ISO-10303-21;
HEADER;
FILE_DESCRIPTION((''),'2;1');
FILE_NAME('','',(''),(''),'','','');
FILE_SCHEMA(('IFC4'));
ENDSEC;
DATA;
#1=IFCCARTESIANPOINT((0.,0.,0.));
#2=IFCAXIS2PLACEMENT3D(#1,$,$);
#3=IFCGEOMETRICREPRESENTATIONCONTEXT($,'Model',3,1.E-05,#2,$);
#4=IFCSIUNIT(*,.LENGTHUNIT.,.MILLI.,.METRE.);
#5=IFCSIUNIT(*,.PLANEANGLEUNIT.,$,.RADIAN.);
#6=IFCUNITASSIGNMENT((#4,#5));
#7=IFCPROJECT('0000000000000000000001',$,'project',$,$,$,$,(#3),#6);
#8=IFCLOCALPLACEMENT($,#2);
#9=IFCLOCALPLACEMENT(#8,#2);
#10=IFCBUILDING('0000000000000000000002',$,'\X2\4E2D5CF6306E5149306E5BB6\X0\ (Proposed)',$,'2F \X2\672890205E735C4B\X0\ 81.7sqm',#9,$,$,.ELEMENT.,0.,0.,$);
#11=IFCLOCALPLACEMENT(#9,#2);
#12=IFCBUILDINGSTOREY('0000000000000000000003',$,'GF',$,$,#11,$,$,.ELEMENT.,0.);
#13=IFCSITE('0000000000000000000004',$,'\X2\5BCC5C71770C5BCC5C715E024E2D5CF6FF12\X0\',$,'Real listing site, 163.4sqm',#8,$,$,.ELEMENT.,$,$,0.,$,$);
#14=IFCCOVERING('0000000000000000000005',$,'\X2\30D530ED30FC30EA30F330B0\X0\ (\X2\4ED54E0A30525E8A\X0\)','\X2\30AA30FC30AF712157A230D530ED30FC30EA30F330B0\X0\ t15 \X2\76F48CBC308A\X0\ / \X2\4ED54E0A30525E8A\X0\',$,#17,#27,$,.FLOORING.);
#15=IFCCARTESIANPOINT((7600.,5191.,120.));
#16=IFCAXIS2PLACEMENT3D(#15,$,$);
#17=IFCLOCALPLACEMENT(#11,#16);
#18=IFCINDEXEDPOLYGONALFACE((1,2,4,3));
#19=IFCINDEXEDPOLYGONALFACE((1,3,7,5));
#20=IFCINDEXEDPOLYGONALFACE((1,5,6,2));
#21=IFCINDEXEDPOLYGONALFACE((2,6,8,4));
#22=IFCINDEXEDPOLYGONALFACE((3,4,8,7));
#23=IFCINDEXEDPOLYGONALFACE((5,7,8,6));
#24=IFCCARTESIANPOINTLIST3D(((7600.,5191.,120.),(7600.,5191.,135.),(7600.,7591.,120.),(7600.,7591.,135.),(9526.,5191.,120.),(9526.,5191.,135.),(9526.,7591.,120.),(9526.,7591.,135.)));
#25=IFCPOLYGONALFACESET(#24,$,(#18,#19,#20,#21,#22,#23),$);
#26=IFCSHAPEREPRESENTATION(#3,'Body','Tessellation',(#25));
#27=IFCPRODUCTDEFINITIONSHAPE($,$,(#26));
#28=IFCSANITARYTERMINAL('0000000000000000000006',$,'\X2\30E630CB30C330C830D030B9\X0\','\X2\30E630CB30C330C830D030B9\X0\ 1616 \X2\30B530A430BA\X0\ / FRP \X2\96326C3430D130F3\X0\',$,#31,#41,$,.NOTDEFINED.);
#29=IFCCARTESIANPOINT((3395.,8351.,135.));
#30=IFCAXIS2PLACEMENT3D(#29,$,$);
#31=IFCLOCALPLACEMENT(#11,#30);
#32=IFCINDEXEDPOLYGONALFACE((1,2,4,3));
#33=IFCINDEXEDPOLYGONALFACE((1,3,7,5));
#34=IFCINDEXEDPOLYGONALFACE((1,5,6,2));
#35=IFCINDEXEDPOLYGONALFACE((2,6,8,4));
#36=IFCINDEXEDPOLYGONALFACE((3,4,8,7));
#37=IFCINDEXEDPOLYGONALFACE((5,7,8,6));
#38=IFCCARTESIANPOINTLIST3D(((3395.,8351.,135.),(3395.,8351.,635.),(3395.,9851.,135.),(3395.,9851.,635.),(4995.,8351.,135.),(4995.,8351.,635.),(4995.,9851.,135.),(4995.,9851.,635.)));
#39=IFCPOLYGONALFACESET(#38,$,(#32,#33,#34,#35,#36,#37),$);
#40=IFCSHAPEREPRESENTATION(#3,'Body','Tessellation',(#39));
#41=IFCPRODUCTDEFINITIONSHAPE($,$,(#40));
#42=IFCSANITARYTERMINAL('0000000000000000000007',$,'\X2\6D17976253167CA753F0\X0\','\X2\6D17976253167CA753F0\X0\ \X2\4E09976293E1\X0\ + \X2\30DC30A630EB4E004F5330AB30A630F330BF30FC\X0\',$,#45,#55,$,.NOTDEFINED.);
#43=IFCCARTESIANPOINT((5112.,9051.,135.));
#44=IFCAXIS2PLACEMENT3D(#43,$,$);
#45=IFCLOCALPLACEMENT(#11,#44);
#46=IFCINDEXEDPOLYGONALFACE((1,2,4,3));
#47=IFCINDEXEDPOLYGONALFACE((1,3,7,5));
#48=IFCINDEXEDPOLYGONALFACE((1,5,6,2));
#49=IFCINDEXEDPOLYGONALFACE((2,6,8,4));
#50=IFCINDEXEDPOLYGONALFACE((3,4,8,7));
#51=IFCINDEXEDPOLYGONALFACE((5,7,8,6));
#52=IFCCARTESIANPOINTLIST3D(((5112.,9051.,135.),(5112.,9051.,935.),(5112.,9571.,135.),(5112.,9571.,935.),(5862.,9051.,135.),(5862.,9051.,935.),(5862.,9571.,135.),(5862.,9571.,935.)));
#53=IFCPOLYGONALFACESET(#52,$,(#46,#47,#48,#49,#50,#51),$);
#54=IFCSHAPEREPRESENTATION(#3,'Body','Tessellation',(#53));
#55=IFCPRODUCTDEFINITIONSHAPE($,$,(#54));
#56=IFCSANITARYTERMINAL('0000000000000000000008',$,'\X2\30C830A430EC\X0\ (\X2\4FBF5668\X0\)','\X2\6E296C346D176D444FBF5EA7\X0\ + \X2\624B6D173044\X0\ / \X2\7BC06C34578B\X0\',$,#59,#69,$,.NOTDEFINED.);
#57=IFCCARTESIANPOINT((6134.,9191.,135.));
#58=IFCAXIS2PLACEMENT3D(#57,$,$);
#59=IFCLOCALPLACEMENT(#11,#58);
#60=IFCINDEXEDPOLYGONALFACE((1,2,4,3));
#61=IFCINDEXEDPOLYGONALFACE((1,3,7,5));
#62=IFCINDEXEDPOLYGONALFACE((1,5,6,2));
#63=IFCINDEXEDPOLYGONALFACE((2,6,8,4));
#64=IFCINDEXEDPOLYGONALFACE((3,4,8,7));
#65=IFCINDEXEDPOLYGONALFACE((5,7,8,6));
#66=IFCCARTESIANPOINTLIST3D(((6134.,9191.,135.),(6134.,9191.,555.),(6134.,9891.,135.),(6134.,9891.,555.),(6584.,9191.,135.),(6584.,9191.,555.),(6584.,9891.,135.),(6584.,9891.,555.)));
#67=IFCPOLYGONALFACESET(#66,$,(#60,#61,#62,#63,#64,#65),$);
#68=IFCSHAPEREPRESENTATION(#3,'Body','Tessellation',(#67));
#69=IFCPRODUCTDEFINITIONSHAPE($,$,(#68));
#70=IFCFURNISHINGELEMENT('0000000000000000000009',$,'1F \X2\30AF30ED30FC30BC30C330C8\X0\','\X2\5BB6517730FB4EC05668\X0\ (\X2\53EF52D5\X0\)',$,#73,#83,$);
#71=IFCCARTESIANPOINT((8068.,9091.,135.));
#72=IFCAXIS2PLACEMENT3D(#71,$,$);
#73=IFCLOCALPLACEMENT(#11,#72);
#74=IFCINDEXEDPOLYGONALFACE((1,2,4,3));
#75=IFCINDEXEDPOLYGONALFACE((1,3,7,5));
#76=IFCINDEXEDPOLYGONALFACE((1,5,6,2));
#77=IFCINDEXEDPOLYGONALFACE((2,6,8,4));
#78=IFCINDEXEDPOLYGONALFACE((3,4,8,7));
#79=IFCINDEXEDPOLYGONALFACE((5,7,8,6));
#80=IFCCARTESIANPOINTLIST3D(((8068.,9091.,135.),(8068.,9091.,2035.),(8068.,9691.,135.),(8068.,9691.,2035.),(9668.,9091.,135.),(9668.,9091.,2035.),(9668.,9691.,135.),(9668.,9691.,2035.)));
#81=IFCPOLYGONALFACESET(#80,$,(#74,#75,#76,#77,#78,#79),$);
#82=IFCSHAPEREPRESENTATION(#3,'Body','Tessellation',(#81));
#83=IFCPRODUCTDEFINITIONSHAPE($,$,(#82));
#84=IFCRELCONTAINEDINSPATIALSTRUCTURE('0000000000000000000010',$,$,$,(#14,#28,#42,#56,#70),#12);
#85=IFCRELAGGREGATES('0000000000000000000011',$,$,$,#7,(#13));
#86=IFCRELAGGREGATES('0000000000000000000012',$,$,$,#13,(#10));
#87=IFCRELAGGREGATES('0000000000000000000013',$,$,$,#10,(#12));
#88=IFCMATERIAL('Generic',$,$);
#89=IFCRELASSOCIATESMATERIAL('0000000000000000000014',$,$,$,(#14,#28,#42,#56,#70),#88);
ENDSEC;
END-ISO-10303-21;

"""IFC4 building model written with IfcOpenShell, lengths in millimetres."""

from ifc_helpers import new_model, si_unit, frame, frame_2d, origin, place, context, project, spatial, rectangle, extrude, material, element, save


model = new_model("IFC4")

# Units and contexts
model_context = context("Model", 3, precision=1e-05, world=origin())
ifc_project = project(units=[si_unit("LENGTHUNIT", "METRE", prefix="MILLI"), si_unit("PLANEANGLEUNIT", "RADIAN")], contexts=[model_context])

# Site, building, storey
site_placement = place(None, origin())
site = spatial("IfcSite", under=ifc_project, at=site_placement, Name="富山県富山市中島２", ObjectType="Real listing site, 163.4sqm", CompositionType="ELEMENT", RefElevation=0.0)
building_placement = place(site_placement, origin())
building = spatial("IfcBuilding", under=site, at=building_placement, Name="中島の光の家 (Proposed)", ObjectType="2F 木造平屋 81.7sqm", CompositionType="ELEMENT", ElevationOfRefHeight=0.0, ElevationOfTerrain=0.0)
storey_placement = place(building_placement, origin())
storey = spatial("IfcBuildingStorey", under=building, at=storey_placement, Name="GF", CompositionType="ELEMENT", Elevation=0.0)

# Covering
ifc_material_1 = material(Name="Generic")
covering_1_placement = place(storey_placement, frame((7600.0, 5191.0, 120.0)))
element("IfcCovering", 1, at=covering_1_placement, inside=storey, material=ifc_material_1, Name="フローリング (仕上げ床)", Description="オーク無垢フローリング t15 直貼り / 仕上げ床", PredefinedType="FLOORING", context=model_context, shape_type="SweptSolid", body=[
    extrude(rectangle(XDim=1926.0, YDim=2400.0, at=frame_2d((963.0, 1200.0))), frame((7600.0, 5191.0, 120.0)), (0.0, 0.0, 1.0), 15.0),
])

# Sanitary terminals
sanitary_terminal_1_placement = place(storey_placement, frame((3395.0, 8351.0, 135.0)))
element("IfcSanitaryTerminal", 2, at=sanitary_terminal_1_placement, inside=storey, material=ifc_material_1, Name="ユニットバス", Description="ユニットバス 1616 サイズ / FRP 防水パン", PredefinedType="NOTDEFINED", context=model_context, shape_type="SweptSolid", body=[
    extrude(rectangle(XDim=1600.0, YDim=1500.0, at=frame_2d((800.0, 750.0))), frame((3395.0, 8351.0, 135.0)), (0.0, 0.0, 1.0), 500.0),
])
sanitary_terminal_2_placement = place(storey_placement, frame((5112.0, 9051.0, 135.0)))
element("IfcSanitaryTerminal", 3, at=sanitary_terminal_2_placement, inside=storey, material=ifc_material_1, Name="洗面化粧台", Description="洗面化粧台 三面鏡 + ボウル一体カウンター", PredefinedType="NOTDEFINED", context=model_context, shape_type="SweptSolid", body=[
    extrude(rectangle(XDim=750.0, YDim=520.0, at=frame_2d((375.0, 260.0))), frame((5112.0, 9051.0, 135.0)), (0.0, 0.0, 1.0), 800.0),
])
sanitary_terminal_3_placement = place(storey_placement, frame((6134.0, 9191.0, 135.0)))
element("IfcSanitaryTerminal", 4, at=sanitary_terminal_3_placement, inside=storey, material=ifc_material_1, Name="トイレ (便器)", Description="温水洗浄便座 + 手洗い / 節水型", PredefinedType="NOTDEFINED", context=model_context, shape_type="SweptSolid", body=[
    extrude(rectangle(XDim=450.0, YDim=700.0, at=frame_2d((225.0, 350.0))), frame((6134.0, 9191.0, 135.0)), (0.0, 0.0, 1.0), 420.0),
])

# Furnishing element
furnishing_placement = place(storey_placement, frame((8068.0, 9091.0, 135.0)))
element("IfcFurnishingElement", 5, at=furnishing_placement, inside=storey, material=ifc_material_1, Name="1F クローゼット", Description="家具・什器 (可動)", context=model_context, shape_type="SweptSolid", body=[
    extrude(rectangle(XDim=1600.0, YDim=600.0, at=frame_2d((800.0, 300.0))), frame((8068.0, 9091.0, 135.0)), (0.0, 0.0, 1.0), 1900.0),
])

save(model, "model.ifc")
